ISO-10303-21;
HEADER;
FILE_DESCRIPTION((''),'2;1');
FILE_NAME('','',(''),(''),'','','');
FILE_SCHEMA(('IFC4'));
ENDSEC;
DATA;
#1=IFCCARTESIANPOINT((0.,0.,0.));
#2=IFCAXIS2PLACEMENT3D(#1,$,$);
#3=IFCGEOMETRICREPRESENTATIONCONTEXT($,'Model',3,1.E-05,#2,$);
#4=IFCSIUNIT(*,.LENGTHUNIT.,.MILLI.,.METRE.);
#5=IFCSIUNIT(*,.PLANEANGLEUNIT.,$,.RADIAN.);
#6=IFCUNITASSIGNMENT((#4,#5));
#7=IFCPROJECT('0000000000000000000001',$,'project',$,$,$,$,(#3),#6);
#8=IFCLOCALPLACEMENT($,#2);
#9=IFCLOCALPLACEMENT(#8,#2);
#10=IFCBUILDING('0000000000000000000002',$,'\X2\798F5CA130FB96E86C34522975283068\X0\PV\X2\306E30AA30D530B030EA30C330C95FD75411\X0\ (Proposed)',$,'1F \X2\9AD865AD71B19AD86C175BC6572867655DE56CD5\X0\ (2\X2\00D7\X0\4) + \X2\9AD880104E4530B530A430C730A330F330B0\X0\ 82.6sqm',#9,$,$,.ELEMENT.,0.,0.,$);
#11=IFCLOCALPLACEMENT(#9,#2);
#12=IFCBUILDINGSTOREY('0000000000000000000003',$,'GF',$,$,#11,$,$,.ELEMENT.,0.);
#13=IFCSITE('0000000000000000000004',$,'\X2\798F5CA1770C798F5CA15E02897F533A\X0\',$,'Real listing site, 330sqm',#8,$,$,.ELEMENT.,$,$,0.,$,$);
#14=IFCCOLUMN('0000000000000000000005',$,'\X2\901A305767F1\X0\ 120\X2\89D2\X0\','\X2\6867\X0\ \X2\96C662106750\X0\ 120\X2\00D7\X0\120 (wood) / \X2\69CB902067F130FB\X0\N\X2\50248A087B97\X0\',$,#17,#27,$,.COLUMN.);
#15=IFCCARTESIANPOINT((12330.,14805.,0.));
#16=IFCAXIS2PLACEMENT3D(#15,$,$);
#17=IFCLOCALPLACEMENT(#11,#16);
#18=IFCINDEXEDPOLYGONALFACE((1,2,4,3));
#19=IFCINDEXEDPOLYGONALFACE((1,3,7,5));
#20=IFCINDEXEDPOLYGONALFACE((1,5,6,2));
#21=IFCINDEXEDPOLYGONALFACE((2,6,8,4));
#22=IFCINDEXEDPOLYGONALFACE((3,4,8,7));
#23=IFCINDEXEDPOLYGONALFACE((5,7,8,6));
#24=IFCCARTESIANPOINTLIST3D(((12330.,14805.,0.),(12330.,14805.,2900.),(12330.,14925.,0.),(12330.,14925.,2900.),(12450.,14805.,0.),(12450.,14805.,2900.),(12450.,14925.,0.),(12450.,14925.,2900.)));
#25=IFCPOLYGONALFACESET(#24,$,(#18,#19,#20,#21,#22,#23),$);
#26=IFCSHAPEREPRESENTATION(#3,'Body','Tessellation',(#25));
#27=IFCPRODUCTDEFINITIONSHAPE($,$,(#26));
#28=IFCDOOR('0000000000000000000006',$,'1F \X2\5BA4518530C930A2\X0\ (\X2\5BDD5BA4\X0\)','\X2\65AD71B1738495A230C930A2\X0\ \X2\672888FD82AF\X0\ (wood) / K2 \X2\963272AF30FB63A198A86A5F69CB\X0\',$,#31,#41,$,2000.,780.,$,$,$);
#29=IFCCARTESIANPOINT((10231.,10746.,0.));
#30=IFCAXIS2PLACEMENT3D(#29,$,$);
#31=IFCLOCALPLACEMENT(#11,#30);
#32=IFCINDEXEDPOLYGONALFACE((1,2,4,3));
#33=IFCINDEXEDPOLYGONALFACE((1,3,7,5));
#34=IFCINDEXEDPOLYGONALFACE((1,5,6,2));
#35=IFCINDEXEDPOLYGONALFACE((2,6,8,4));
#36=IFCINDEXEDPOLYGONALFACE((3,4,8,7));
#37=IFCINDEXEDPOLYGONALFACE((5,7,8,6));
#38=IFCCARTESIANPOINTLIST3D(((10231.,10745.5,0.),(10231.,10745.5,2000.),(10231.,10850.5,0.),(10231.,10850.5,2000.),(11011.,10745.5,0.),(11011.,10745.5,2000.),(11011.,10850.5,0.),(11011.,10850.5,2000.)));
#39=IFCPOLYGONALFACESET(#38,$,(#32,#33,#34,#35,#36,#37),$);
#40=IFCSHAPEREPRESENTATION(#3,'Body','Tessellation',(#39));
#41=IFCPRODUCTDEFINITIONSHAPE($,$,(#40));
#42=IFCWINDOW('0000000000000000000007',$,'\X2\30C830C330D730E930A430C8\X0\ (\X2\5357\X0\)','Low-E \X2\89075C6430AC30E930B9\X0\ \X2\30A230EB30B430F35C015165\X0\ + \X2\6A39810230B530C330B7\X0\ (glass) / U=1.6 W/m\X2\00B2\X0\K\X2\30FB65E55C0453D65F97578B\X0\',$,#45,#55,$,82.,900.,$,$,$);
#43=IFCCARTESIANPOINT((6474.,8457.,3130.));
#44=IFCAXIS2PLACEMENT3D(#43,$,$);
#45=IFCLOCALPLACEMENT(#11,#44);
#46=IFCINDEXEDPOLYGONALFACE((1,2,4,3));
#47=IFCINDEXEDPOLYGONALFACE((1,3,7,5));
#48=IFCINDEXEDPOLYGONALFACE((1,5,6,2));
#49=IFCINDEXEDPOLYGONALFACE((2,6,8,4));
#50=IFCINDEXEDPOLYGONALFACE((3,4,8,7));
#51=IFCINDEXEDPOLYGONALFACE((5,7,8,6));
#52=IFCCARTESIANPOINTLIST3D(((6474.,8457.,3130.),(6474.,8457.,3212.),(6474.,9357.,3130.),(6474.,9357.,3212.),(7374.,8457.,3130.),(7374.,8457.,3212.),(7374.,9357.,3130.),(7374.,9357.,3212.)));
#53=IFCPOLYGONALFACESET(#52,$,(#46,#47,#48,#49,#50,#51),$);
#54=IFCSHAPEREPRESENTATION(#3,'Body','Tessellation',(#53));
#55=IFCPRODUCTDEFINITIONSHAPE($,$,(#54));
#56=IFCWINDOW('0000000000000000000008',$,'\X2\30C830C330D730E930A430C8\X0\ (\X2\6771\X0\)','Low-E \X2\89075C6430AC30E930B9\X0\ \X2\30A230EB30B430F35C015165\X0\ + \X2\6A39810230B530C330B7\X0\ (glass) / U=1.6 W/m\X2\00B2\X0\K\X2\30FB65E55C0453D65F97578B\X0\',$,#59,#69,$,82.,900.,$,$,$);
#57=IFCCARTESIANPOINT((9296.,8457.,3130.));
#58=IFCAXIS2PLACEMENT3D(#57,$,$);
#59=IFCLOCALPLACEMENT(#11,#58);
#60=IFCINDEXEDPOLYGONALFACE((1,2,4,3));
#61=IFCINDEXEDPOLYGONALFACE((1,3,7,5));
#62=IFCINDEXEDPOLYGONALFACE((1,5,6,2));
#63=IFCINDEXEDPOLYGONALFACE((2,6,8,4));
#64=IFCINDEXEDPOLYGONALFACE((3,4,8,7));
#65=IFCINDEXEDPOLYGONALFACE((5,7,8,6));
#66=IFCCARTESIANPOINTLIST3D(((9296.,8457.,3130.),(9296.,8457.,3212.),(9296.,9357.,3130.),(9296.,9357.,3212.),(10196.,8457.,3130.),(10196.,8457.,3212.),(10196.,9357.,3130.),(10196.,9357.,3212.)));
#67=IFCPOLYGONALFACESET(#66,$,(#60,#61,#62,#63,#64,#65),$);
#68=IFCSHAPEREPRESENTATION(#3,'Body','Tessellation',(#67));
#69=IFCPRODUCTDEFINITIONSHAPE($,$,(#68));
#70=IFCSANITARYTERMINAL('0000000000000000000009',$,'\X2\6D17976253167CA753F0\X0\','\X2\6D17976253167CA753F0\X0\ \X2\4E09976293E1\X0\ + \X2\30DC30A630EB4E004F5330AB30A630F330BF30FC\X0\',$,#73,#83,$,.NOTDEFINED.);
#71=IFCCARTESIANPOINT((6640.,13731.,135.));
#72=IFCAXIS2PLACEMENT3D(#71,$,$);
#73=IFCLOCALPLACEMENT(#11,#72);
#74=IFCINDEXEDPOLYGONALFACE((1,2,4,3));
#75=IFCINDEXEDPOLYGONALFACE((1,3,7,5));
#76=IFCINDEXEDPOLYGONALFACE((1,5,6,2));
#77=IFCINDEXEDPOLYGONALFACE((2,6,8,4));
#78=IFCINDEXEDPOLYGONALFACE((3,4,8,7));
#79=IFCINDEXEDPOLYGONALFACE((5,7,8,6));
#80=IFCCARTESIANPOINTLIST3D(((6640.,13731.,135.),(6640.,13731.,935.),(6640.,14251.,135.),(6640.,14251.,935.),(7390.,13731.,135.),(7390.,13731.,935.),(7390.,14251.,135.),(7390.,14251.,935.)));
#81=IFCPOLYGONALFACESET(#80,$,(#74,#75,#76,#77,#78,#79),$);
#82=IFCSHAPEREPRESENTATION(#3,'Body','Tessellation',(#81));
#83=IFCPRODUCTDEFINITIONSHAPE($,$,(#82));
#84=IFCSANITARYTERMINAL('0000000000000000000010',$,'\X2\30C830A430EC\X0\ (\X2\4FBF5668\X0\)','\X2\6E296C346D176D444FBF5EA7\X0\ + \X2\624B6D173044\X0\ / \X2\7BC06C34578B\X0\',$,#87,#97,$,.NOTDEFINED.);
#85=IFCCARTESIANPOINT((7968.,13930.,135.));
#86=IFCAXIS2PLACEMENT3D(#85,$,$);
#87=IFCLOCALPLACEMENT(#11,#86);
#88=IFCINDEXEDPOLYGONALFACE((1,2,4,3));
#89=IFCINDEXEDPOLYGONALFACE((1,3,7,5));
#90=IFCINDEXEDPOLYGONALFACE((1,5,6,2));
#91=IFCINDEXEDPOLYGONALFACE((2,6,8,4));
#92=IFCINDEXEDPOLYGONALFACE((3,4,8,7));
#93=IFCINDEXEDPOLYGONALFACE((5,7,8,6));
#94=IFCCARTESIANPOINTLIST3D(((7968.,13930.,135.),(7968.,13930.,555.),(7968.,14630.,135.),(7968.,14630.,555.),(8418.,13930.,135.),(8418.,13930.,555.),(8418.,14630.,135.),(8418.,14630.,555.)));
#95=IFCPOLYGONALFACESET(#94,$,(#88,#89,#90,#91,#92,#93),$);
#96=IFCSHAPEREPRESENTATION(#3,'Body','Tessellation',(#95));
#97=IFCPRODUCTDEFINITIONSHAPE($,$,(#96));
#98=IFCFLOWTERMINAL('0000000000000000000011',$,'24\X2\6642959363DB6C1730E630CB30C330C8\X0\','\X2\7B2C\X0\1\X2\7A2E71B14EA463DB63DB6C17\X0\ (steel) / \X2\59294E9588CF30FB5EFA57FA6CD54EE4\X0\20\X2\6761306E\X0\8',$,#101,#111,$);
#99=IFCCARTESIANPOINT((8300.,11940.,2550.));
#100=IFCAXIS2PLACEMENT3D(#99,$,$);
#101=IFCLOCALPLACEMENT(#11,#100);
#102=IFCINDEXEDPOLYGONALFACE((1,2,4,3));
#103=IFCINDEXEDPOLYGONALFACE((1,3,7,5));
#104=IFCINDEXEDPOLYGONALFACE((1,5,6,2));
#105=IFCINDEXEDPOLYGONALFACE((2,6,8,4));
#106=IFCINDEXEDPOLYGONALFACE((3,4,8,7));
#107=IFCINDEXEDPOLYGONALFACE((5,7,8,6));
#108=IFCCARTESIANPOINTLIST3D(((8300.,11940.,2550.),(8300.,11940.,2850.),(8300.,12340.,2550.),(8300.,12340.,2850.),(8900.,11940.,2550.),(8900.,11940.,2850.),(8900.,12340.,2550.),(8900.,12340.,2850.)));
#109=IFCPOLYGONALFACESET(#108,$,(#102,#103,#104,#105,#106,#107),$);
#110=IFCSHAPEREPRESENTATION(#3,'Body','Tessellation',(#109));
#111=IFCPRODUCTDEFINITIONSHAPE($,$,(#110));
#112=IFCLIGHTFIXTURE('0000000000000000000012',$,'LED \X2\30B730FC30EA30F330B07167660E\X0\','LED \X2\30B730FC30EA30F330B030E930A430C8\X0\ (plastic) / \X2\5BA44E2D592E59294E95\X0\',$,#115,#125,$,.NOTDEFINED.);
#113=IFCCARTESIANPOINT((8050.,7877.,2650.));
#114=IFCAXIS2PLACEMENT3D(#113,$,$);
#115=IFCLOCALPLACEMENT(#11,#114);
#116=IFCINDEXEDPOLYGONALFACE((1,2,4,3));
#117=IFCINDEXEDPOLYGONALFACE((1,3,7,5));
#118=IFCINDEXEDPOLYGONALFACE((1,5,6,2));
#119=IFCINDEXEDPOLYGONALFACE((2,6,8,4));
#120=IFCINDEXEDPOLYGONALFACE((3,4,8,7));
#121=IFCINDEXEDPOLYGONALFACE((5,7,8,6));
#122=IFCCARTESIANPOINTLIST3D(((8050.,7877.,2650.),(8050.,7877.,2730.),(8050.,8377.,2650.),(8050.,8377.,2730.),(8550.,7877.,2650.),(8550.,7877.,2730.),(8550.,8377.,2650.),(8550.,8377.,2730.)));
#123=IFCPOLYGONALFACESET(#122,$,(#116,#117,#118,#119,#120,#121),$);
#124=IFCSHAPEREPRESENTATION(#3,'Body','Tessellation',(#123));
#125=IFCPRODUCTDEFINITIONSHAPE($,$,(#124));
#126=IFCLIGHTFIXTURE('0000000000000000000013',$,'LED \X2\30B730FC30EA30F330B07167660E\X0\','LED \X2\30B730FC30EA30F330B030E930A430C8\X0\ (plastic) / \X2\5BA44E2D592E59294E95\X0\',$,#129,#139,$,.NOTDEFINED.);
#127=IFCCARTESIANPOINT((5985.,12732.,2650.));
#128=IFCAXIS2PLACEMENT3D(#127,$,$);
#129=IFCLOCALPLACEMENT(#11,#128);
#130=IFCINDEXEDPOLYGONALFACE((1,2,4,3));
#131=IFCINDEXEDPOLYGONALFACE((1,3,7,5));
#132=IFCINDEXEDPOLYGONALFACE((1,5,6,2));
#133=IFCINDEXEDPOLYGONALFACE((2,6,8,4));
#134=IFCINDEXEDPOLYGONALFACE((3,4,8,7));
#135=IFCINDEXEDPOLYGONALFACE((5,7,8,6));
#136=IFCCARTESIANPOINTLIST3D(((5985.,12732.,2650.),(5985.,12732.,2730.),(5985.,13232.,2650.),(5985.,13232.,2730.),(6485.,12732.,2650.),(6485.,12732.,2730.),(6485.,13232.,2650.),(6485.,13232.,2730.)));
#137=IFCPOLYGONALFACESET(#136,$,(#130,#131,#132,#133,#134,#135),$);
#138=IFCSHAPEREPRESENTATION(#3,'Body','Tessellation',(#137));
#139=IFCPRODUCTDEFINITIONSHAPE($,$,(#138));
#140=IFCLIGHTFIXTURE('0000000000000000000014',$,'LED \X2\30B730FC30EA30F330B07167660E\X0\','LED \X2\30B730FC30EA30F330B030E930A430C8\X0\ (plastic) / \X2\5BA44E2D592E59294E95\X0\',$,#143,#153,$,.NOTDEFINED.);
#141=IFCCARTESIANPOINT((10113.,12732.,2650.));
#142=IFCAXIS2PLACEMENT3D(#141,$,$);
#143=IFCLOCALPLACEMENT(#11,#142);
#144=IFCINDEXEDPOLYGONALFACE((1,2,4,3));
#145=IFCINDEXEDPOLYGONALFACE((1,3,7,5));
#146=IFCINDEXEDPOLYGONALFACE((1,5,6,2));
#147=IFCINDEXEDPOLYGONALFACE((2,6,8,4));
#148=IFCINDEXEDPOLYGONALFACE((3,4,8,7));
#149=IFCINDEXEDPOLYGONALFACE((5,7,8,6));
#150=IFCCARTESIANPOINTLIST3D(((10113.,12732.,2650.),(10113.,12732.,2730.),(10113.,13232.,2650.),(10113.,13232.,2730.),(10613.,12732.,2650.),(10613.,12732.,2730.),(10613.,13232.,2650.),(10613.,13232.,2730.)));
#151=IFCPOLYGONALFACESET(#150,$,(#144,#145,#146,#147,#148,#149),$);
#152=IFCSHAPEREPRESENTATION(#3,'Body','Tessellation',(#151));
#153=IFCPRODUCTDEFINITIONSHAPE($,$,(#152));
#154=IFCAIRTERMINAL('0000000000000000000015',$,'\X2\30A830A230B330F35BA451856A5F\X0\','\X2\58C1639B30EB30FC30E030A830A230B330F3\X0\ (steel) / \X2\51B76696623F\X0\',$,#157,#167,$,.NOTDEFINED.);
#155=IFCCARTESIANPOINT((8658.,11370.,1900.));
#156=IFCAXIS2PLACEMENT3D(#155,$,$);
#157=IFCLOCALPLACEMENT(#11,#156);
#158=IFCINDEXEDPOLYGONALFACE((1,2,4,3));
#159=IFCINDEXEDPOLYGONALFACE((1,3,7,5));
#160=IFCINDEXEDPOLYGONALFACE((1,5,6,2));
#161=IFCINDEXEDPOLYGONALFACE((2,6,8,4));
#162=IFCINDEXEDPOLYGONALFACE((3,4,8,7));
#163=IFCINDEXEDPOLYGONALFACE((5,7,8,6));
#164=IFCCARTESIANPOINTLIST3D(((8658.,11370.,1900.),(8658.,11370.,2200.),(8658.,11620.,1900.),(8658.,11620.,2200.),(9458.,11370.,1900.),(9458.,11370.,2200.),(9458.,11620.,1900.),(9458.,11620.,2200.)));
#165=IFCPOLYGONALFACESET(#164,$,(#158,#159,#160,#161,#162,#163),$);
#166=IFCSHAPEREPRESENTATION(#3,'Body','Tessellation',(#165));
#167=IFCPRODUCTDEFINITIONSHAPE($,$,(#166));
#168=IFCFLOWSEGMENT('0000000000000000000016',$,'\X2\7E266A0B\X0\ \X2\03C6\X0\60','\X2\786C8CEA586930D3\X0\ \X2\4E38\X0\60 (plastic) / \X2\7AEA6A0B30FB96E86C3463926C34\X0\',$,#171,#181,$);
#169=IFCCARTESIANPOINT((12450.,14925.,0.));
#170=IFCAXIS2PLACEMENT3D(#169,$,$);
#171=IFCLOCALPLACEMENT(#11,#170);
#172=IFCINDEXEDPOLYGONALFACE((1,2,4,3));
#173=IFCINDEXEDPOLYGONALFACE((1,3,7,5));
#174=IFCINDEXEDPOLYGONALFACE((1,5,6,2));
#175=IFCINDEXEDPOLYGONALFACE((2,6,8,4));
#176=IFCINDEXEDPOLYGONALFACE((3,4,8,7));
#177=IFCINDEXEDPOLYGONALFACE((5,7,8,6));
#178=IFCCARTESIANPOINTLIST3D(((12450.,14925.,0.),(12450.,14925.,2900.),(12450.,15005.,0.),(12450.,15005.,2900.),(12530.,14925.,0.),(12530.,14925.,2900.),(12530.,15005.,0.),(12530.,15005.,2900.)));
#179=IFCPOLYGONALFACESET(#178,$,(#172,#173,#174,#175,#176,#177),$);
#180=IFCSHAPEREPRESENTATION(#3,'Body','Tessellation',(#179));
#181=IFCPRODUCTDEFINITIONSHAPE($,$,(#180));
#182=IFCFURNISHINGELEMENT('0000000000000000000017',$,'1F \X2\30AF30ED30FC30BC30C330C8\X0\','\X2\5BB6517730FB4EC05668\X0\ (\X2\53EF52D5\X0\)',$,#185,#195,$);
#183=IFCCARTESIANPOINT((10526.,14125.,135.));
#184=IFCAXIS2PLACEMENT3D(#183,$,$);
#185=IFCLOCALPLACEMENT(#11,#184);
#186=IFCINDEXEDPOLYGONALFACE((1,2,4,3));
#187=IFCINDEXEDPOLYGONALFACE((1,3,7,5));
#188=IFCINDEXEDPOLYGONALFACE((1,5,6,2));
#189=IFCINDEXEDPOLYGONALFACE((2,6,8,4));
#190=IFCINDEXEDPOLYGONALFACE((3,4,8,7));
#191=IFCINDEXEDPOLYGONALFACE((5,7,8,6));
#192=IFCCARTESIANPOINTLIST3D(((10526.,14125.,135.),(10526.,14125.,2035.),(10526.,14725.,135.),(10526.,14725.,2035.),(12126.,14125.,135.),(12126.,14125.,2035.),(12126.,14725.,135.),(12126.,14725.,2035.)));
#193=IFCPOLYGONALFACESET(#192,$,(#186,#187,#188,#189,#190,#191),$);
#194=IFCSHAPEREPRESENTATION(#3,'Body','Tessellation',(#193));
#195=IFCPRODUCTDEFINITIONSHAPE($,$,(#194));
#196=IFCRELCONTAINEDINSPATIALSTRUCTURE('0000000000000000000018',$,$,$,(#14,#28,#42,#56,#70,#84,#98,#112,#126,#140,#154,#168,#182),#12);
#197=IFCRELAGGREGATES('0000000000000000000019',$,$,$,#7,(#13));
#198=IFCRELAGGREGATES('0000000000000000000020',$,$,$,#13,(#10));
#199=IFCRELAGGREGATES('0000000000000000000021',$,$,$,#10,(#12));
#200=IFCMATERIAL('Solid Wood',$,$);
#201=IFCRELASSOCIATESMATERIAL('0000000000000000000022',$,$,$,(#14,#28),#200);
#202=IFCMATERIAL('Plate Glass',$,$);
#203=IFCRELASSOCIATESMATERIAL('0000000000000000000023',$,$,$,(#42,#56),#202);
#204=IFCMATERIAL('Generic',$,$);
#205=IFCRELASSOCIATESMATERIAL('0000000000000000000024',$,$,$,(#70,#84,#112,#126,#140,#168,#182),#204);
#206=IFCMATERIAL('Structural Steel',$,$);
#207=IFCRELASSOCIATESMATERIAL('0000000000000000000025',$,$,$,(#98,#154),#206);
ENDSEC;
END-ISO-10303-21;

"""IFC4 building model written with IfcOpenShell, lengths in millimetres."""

from ifc_helpers import new_model, si_unit, frame, frame_2d, origin, place, context, project, spatial, rectangle, extrude, material, element, save


model = new_model("IFC4")

# Units and contexts
model_context = context("Model", 3, precision=1e-05, world=origin())
ifc_project = project(units=[si_unit("LENGTHUNIT", "METRE", prefix="MILLI"), si_unit("PLANEANGLEUNIT", "RADIAN")], contexts=[model_context])

# Site, building, storey
site_placement = place(None, origin())
site = spatial("IfcSite", under=ifc_project, at=site_placement, Name="福岡県福岡市西区", ObjectType="Real listing site, 330sqm", CompositionType="ELEMENT", RefElevation=0.0)
building_placement = place(site_placement, origin())
building = spatial("IfcBuilding", under=site, at=building_placement, Name="福岡・雨水利用とPVのオフグリッド志向 (Proposed)", ObjectType="1F 高断熱高気密在来工法 (2×4) + 高耐久サイディング 82.6sqm", CompositionType="ELEMENT", ElevationOfRefHeight=0.0, ElevationOfTerrain=0.0)
storey_placement = place(building_placement, origin())
storey = spatial("IfcBuildingStorey", under=building, at=storey_placement, Name="GF", CompositionType="ELEMENT", Elevation=0.0)

# Column
ifc_material_1 = material(Name="Solid Wood")
column_1_placement = place(storey_placement, frame((12330.0, 14805.0, 0.0)))
element("IfcColumn", 1, at=column_1_placement, inside=storey, material=ifc_material_1, Name="通し柱 120角", Description="桧 集成材 120×120 (wood) / 構造柱・N値計算", PredefinedType="COLUMN", context=model_context, shape_type="SweptSolid", body=[
    extrude(rectangle(XDim=120.0, YDim=120.0, at=frame_2d((60.0, 60.0))), frame((12330.0, 14805.0, 0.0)), (0.0, 0.0, 1.0), 2900.0),
])

# Door
door_placement = place(storey_placement, frame((10231.0, 10746.0, 0.0)))
element("IfcDoor", 2, at=door_placement, inside=storey, material=ifc_material_1, Name="1F 室内ドア (寝室)", Description="断熱玄関ドア 木製芯 (wood) / K2 防犯・採風機構", OverallHeight=2000.0, OverallWidth=780.0, context=model_context, shape_type="SweptSolid", body=[
    extrude(rectangle(XDim=780.0, YDim=105.0, at=frame_2d((390.0, 52.0))), frame((10231.0, 10746.0, 0.0)), (0.0, 0.0, 1.0), 2000.0),
])

# Windows
ifc_material_2 = material(Name="Plate Glass")
window_1_placement = place(storey_placement, frame((6474.0, 8457.0, 3130.0)))
element("IfcWindow", 3, at=window_1_placement, inside=storey, material=ifc_material_2, Name="トップライト (南)", Description="Low-E 複層ガラス アルゴン封入 + 樹脂サッシ (glass) / U=1.6 W/m²K・日射取得型", OverallHeight=82.0, OverallWidth=900.0, context=model_context, shape_type="SweptSolid", body=[
    extrude(rectangle(XDim=900.0, YDim=900.0, at=frame_2d((450.0, 450.0))), frame((6474.0, 8457.0, 3130.0)), (0.0, 0.0, 1.0), 82.0),
])
window_2_placement = place(storey_placement, frame((9296.0, 8457.0, 3130.0)))
element("IfcWindow", 4, at=window_2_placement, inside=storey, material=ifc_material_2, Name="トップライト (東)", Description="Low-E 複層ガラス アルゴン封入 + 樹脂サッシ (glass) / U=1.6 W/m²K・日射取得型", OverallHeight=82.0, OverallWidth=900.0, context=model_context, shape_type="SweptSolid", body=[
    extrude(rectangle(XDim=900.0, YDim=900.0, at=frame_2d((450.0, 450.0))), frame((9296.0, 8457.0, 3130.0)), (0.0, 0.0, 1.0), 82.0),
])

# Sanitary terminals
ifc_material_3 = material(Name="Generic")
sanitary_terminal_1_placement = place(storey_placement, frame((6640.0, 13731.0, 135.0)))
element("IfcSanitaryTerminal", 5, at=sanitary_terminal_1_placement, inside=storey, material=ifc_material_3, Name="洗面化粧台", Description="洗面化粧台 三面鏡 + ボウル一体カウンター", PredefinedType="NOTDEFINED", context=model_context, shape_type="SweptSolid", body=[
    extrude(rectangle(XDim=750.0, YDim=520.0, at=frame_2d((375.0, 260.0))), frame((6640.0, 13731.0, 135.0)), (0.0, 0.0, 1.0), 800.0),
])
sanitary_terminal_2_placement = place(storey_placement, frame((7968.0, 13930.0, 135.0)))
element("IfcSanitaryTerminal", 6, at=sanitary_terminal_2_placement, inside=storey, material=ifc_material_3, Name="トイレ (便器)", Description="温水洗浄便座 + 手洗い / 節水型", PredefinedType="NOTDEFINED", context=model_context, shape_type="SweptSolid", body=[
    extrude(rectangle(XDim=450.0, YDim=700.0, at=frame_2d((225.0, 350.0))), frame((7968.0, 13930.0, 135.0)), (0.0, 0.0, 1.0), 420.0),
])

# Flow terminal
ifc_material_4 = material(Name="Structural Steel")
flow_terminal_placement = place(storey_placement, frame((8300.0, 11940.0, 2550.0)))
element("IfcFlowTerminal", 7, at=flow_terminal_placement, inside=storey, material=ifc_material_4, Name="24時間換気ユニット", Description="第1種熱交換換気 (steel) / 天井裏・建基法令20条の8", context=model_context, shape_type="SweptSolid", body=[
    extrude(rectangle(XDim=600.0, YDim=400.0, at=frame_2d((300.0, 200.0))), frame((8300.0, 11940.0, 2550.0)), (0.0, 0.0, 1.0), 300.0),
])

# Light fixtures
light_fixture_1_placement = place(storey_placement, frame((8050.0, 7877.0, 2650.0)))
element("IfcLightFixture", 8, at=light_fixture_1_placement, inside=storey, material=ifc_material_3, Name="LED シーリング照明", Description="LED シーリングライト (plastic) / 室中央天井", PredefinedType="NOTDEFINED", context=model_context, shape_type="SweptSolid", body=[
    extrude(rectangle(XDim=500.0, YDim=500.0, at=frame_2d((250.0, 250.0))), frame((8050.0, 7877.0, 2650.0)), (0.0, 0.0, 1.0), 80.0),
])
light_fixture_2_placement = place(storey_placement, frame((5985.0, 12732.0, 2650.0)))
element("IfcLightFixture", 9, at=light_fixture_2_placement, inside=storey, material=ifc_material_3, Name="LED シーリング照明", Description="LED シーリングライト (plastic) / 室中央天井", PredefinedType="NOTDEFINED", context=model_context, shape_type="SweptSolid", body=[
    extrude(rectangle(XDim=500.0, YDim=500.0, at=frame_2d((250.0, 250.0))), frame((5985.0, 12732.0, 2650.0)), (0.0, 0.0, 1.0), 80.0),
])
light_fixture_3_placement = place(storey_placement, frame((10113.0, 12732.0, 2650.0)))
element("IfcLightFixture", 10, at=light_fixture_3_placement, inside=storey, material=ifc_material_3, Name="LED シーリング照明", Description="LED シーリングライト (plastic) / 室中央天井", PredefinedType="NOTDEFINED", context=model_context, shape_type="SweptSolid", body=[
    extrude(rectangle(XDim=500.0, YDim=500.0, at=frame_2d((250.0, 250.0))), frame((10113.0, 12732.0, 2650.0)), (0.0, 0.0, 1.0), 80.0),
])

# Air terminal
air_terminal_placement = place(storey_placement, frame((8658.0, 11370.0, 1900.0)))
element("IfcAirTerminal", 11, at=air_terminal_placement, inside=storey, material=ifc_material_4, Name="エアコン室内機", Description="壁掛ルームエアコン (steel) / 冷暖房", PredefinedType="NOTDEFINED", context=model_context, shape_type="SweptSolid", body=[
    extrude(rectangle(XDim=800.0, YDim=250.0, at=frame_2d((400.0, 125.0))), frame((8658.0, 11370.0, 1900.0)), (0.0, 0.0, 1.0), 300.0),
])

# Flow segment
flow_segment_placement = place(storey_placement, frame((12450.0, 14925.0, 0.0)))
element("IfcFlowSegment", 12, at=flow_segment_placement, inside=storey, material=ifc_material_3, Name="縦樋 φ60", Description="硬質塩ビ 丸60 (plastic) / 竪樋・雨水排水", context=model_context, shape_type="SweptSolid", body=[
    extrude(rectangle(XDim=80.0, YDim=80.0, at=frame_2d((40.0, 40.0))), frame((12450.0, 14925.0, 0.0)), (0.0, 0.0, 1.0), 2900.0),
])

# Furnishing element
furnishing_placement = place(storey_placement, frame((10526.0, 14125.0, 135.0)))
element("IfcFurnishingElement", 13, at=furnishing_placement, inside=storey, material=ifc_material_3, Name="1F クローゼット", Description="家具・什器 (可動)", context=model_context, shape_type="SweptSolid", body=[
    extrude(rectangle(XDim=1600.0, YDim=600.0, at=frame_2d((800.0, 300.0))), frame((10526.0, 14125.0, 135.0)), (0.0, 0.0, 1.0), 1900.0),
])

save(model, "model.ifc")
